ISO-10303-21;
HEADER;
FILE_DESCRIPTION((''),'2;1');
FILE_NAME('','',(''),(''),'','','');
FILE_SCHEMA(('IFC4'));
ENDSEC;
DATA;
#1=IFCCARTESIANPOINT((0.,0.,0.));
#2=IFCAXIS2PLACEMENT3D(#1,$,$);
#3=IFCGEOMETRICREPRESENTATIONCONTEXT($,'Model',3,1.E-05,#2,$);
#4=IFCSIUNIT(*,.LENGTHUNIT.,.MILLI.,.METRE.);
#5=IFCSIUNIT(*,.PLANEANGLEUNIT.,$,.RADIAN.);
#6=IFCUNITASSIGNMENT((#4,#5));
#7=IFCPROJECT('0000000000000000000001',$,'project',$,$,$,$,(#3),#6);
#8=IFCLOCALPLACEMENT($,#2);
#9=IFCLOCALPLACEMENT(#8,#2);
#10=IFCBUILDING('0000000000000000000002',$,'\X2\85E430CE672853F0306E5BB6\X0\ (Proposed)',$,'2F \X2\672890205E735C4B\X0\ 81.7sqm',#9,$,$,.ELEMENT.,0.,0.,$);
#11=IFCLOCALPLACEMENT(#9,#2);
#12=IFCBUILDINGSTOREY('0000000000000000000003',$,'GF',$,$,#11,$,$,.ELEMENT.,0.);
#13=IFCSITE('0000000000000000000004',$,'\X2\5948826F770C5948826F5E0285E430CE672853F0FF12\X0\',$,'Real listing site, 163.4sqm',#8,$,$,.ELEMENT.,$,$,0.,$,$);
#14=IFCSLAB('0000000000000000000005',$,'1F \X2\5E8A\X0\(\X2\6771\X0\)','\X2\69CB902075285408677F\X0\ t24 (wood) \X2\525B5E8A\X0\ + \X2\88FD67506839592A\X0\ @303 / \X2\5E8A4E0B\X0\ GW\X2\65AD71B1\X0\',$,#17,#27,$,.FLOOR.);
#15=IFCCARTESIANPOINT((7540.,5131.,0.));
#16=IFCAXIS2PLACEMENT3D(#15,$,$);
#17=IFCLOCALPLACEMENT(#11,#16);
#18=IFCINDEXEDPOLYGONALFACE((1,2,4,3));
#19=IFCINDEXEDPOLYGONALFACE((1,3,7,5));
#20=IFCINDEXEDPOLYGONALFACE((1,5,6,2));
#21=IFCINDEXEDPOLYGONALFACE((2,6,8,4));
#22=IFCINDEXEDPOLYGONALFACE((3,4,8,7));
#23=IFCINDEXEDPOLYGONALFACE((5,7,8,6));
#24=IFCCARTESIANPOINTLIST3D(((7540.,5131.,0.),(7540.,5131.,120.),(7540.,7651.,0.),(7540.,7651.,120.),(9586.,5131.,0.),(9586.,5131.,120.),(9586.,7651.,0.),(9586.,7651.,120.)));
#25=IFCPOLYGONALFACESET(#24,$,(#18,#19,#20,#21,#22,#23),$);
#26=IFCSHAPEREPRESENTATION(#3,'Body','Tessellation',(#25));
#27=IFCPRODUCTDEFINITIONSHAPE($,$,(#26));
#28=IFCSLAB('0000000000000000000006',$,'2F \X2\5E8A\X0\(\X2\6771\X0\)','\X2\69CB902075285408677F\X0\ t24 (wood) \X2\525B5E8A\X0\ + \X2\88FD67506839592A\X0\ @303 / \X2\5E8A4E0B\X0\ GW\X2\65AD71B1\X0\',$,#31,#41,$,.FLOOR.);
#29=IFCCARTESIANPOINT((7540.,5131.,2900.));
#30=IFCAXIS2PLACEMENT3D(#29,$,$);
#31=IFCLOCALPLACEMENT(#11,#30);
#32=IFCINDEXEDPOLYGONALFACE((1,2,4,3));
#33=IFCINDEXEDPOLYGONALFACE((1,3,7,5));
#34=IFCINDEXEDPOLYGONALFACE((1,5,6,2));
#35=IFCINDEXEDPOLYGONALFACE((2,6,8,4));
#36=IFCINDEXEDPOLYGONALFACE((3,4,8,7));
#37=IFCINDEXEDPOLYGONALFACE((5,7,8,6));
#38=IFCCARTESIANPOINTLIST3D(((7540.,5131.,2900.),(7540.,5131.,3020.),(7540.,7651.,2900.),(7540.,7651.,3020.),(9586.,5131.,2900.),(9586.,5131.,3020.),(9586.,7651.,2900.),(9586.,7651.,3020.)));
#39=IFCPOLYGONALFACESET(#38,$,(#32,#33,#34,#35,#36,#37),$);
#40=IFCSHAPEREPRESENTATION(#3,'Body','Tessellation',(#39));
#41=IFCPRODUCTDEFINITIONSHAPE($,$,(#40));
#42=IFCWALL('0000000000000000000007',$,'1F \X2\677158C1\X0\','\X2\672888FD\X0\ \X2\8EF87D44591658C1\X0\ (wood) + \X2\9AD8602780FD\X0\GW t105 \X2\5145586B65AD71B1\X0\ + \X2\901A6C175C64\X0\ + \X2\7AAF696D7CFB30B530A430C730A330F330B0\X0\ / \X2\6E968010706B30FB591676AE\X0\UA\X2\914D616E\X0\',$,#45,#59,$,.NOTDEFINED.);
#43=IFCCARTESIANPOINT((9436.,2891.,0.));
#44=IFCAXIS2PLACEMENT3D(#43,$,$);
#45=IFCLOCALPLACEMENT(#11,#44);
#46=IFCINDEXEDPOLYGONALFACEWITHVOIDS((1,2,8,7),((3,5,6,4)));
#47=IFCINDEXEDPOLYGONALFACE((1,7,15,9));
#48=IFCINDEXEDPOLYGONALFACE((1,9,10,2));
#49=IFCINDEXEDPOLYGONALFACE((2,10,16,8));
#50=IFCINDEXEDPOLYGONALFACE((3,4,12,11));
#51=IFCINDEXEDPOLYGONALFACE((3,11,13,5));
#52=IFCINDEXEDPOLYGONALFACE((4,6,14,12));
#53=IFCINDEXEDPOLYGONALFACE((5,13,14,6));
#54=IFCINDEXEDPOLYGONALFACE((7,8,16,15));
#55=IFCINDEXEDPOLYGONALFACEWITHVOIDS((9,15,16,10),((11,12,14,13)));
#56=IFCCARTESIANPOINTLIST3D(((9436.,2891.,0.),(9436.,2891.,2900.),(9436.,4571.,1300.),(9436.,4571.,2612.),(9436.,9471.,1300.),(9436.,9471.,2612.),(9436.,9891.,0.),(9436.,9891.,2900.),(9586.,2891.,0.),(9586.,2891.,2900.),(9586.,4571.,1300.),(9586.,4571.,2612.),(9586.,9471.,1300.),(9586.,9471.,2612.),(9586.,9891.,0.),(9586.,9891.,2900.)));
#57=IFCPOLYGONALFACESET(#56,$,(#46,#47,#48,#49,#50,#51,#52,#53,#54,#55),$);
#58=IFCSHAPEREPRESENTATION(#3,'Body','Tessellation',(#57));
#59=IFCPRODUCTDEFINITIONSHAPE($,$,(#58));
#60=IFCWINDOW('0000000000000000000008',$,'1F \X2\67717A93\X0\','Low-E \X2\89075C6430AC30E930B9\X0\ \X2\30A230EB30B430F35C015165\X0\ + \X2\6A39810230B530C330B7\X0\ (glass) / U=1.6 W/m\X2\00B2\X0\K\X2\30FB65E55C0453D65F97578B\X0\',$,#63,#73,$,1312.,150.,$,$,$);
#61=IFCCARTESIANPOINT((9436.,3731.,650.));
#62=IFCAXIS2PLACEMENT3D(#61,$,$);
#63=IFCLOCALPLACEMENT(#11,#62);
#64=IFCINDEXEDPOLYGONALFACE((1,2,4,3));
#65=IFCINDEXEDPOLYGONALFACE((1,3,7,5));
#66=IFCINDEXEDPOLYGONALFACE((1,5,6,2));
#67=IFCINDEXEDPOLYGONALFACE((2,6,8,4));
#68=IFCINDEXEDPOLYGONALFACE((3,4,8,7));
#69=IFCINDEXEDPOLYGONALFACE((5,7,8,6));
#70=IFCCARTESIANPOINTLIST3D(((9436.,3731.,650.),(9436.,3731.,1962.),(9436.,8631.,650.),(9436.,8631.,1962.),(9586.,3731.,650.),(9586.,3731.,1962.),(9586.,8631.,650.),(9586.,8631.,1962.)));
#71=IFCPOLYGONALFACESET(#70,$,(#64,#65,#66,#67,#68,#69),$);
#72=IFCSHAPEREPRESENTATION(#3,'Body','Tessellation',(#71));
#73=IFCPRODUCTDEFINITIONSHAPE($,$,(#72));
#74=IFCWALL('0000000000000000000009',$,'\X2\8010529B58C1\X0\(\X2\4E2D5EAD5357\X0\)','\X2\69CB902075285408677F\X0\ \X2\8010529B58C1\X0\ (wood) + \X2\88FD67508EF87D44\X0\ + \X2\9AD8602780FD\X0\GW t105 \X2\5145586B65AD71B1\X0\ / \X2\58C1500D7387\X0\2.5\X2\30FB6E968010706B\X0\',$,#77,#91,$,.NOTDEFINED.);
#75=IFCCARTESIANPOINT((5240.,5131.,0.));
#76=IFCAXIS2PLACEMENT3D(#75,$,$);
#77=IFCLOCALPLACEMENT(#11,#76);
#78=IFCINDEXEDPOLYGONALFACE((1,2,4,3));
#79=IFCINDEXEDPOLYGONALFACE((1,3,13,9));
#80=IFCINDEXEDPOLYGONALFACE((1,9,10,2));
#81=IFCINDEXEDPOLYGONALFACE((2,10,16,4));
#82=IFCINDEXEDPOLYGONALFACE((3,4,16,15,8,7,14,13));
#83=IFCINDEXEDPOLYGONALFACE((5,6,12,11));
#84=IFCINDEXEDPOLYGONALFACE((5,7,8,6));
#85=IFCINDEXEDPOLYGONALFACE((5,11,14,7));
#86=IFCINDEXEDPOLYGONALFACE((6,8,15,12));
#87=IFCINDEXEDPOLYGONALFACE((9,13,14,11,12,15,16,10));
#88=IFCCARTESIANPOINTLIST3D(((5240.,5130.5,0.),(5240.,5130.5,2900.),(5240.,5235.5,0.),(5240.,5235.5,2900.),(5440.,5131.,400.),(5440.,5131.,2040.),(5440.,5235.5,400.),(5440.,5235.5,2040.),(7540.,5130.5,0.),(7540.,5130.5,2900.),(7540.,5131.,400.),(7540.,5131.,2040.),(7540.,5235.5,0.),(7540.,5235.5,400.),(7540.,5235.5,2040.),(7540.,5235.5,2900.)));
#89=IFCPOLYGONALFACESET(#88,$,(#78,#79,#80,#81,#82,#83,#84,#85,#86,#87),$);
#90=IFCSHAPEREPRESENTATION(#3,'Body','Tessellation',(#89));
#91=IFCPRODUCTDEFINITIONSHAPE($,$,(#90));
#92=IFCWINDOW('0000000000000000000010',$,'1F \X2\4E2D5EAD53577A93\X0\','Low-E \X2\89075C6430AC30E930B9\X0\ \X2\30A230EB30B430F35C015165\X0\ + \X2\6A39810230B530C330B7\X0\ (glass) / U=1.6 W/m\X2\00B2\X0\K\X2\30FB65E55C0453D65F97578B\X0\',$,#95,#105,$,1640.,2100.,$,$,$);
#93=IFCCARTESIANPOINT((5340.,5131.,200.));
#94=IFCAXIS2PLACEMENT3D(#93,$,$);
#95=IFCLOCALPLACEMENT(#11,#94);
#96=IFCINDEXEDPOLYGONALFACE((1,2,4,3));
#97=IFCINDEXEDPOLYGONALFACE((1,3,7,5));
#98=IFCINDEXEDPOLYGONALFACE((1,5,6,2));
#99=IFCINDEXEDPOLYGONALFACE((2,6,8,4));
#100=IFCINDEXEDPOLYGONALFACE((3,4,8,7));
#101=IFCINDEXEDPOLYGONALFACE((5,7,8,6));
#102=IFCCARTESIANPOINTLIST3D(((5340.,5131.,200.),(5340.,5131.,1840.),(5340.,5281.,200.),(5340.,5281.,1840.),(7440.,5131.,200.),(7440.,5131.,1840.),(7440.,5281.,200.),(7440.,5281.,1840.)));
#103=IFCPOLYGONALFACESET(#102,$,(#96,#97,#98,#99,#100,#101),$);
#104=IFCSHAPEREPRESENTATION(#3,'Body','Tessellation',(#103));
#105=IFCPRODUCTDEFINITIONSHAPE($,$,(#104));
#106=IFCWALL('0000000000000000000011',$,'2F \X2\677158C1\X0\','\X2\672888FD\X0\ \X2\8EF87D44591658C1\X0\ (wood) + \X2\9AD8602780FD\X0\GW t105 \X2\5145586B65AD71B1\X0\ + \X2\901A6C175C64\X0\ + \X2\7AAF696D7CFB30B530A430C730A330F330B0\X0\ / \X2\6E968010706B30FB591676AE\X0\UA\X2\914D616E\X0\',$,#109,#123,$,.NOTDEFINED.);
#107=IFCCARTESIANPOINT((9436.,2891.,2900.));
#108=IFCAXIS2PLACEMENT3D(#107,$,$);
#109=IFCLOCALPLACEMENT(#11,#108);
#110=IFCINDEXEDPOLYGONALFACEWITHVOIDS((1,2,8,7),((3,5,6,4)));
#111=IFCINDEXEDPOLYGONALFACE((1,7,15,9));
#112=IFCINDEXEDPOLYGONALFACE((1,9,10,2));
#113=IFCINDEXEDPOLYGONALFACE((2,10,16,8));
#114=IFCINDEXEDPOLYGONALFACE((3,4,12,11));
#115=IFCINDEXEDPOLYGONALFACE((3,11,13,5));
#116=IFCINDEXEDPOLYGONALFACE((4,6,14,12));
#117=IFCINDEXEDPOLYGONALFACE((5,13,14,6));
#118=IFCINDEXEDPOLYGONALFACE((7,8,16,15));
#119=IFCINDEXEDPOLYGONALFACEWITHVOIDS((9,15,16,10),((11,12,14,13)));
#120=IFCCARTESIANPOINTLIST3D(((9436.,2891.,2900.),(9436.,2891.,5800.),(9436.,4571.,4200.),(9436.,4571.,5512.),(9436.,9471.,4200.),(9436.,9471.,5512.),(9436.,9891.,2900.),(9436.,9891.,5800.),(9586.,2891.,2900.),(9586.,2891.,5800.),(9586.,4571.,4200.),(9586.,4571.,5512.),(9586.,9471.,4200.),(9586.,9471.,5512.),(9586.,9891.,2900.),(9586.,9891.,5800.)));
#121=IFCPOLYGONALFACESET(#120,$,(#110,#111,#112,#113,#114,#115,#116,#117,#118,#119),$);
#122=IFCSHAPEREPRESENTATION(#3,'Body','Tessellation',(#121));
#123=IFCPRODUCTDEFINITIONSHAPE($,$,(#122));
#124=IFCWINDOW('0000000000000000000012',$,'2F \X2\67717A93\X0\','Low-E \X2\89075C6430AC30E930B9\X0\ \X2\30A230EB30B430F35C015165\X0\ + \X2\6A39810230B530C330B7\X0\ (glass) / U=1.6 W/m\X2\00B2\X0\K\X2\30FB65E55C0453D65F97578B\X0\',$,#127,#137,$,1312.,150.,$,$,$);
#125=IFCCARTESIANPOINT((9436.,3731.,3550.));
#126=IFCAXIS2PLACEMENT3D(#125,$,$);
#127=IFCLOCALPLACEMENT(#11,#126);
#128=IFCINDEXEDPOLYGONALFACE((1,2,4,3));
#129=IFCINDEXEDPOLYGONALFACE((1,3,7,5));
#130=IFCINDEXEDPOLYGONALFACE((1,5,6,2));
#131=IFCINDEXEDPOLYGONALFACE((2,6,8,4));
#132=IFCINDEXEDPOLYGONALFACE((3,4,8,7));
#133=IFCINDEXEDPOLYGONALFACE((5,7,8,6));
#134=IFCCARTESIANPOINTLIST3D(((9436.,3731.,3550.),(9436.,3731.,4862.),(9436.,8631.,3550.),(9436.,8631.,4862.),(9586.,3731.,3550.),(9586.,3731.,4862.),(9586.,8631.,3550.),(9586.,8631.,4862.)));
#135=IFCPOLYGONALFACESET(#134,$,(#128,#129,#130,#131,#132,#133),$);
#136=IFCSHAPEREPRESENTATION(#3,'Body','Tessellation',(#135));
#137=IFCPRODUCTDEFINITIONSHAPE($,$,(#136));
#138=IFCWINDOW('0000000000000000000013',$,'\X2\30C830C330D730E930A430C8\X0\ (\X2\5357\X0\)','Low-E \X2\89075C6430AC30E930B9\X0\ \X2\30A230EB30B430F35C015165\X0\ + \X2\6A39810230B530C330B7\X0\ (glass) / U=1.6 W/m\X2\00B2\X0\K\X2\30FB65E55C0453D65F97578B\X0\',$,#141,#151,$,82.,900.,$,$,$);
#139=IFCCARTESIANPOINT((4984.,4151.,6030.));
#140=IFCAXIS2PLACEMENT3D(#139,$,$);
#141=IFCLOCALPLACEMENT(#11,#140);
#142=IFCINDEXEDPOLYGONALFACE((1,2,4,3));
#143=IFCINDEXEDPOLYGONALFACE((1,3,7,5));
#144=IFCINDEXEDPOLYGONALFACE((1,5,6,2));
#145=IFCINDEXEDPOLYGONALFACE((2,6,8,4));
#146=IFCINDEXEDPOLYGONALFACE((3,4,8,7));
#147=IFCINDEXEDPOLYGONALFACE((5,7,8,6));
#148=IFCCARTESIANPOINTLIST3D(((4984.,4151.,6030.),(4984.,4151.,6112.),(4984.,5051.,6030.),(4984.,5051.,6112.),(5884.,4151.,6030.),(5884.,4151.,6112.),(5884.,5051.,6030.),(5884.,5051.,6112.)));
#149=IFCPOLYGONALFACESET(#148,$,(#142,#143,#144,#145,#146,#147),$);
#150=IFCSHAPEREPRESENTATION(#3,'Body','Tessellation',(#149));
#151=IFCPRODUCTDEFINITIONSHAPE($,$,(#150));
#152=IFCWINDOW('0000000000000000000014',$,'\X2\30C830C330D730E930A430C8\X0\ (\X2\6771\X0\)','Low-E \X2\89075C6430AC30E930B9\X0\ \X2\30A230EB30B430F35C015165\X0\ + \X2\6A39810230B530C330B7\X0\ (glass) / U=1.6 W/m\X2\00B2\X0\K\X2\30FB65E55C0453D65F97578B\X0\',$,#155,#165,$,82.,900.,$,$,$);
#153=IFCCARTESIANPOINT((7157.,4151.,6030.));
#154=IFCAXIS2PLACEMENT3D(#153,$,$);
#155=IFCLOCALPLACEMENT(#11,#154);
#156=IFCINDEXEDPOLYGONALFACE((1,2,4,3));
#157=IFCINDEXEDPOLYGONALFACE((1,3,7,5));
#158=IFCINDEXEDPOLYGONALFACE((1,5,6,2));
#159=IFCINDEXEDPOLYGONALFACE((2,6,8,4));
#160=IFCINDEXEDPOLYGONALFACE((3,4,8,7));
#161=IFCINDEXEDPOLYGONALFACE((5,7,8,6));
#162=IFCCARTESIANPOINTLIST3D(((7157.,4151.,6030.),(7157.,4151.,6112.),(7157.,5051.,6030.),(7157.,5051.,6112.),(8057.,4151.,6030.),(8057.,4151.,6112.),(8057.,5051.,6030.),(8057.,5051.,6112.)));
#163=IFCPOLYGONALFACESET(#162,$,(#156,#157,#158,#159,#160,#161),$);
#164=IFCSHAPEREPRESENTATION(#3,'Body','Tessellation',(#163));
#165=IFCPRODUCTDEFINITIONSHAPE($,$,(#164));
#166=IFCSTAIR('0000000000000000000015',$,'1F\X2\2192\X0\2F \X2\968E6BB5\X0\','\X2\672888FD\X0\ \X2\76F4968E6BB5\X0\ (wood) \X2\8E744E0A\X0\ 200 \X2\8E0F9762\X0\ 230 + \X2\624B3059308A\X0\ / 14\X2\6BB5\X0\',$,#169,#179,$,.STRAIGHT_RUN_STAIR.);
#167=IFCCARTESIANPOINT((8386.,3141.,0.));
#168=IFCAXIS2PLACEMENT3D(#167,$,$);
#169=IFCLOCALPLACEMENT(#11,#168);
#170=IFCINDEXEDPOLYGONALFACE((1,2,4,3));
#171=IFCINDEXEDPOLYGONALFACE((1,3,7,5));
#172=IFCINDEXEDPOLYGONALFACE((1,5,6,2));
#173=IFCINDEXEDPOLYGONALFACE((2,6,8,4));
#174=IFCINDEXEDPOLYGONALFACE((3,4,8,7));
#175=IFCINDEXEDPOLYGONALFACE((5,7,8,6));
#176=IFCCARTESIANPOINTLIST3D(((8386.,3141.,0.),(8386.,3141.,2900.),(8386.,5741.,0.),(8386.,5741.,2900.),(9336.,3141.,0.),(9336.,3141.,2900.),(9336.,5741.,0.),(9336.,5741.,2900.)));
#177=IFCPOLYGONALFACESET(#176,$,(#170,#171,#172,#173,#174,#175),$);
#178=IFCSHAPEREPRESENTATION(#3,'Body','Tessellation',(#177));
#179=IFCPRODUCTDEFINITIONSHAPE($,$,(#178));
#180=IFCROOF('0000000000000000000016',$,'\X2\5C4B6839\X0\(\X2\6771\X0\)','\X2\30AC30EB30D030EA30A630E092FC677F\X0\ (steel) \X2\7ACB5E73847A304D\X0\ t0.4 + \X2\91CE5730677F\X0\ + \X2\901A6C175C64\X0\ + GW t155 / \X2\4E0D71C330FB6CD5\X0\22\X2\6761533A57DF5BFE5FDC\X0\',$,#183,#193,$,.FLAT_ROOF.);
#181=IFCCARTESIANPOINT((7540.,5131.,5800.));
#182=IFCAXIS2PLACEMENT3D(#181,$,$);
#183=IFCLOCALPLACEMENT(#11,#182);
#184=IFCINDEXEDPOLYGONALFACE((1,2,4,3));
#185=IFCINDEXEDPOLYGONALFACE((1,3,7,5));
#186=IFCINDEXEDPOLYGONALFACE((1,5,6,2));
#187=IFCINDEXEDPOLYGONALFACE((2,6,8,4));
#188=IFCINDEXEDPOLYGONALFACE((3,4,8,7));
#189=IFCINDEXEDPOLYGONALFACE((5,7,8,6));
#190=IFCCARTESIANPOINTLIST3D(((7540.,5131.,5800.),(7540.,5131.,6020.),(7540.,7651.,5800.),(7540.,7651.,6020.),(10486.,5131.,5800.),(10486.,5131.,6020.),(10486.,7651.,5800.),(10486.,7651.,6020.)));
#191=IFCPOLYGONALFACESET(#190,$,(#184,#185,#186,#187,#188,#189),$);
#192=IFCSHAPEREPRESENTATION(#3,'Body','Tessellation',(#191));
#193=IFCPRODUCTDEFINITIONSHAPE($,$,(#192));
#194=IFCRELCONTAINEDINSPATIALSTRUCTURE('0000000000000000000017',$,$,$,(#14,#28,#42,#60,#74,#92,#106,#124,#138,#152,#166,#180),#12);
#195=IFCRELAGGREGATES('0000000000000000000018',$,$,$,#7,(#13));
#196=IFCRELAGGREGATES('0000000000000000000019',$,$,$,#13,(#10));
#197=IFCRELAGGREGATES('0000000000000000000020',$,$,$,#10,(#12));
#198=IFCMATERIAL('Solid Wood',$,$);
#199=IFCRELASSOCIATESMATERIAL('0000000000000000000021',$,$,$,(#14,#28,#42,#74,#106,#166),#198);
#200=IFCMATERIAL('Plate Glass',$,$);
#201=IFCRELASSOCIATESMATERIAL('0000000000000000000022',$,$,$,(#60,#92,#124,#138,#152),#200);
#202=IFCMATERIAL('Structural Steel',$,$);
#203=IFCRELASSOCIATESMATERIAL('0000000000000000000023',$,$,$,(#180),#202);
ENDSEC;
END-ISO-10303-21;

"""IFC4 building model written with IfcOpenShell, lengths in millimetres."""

from ifc_helpers import new_model, si_unit, frame, frame_2d, origin, place, context, project, spatial, rectangle, extrude, material, element, fill, save


model = new_model("IFC4")

# Units and contexts
model_context = context("Model", 3, precision=1e-05, world=origin())
ifc_project = project(units=[si_unit("LENGTHUNIT", "METRE", prefix="MILLI"), si_unit("PLANEANGLEUNIT", "RADIAN")], contexts=[model_context])

# Site, building, storey
site_placement = place(None, origin())
site = spatial("IfcSite", under=ifc_project, at=site_placement, Name="奈良県奈良市藤ノ木台２", ObjectType="Real listing site, 163.4sqm", CompositionType="ELEMENT", RefElevation=0.0)
building_placement = place(site_placement, origin())
building = spatial("IfcBuilding", under=site, at=building_placement, Name="藤ノ木台の家 (Proposed)", ObjectType="2F 木造平屋 81.7sqm", CompositionType="ELEMENT", ElevationOfRefHeight=0.0, ElevationOfTerrain=0.0)
storey_placement = place(building_placement, origin())
storey = spatial("IfcBuildingStorey", under=building, at=storey_placement, Name="GF", CompositionType="ELEMENT", Elevation=0.0)

# Slabs
ifc_material_1 = material(Name="Solid Wood")
slab_1_placement = place(storey_placement, frame((7540.0, 5131.0, 0.0)))
element("IfcSlab", 1, at=slab_1_placement, inside=storey, material=ifc_material_1, Name="1F 床(東)", Description="構造用合板 t24 (wood) 剛床 + 製材根太 @303 / 床下 GW断熱", PredefinedType="FLOOR", context=model_context, shape_type="SweptSolid", body=[
    extrude(rectangle(XDim=2046.0, YDim=2520.0, at=frame_2d((1023.0, 1260.0))), frame((7540.0, 5131.0, 0.0)), (0.0, 0.0, 1.0), 120.0),
])
slab_2_placement = place(storey_placement, frame((7540.0, 5131.0, 2900.0)))
element("IfcSlab", 2, at=slab_2_placement, inside=storey, material=ifc_material_1, Name="2F 床(東)", Description="構造用合板 t24 (wood) 剛床 + 製材根太 @303 / 床下 GW断熱", PredefinedType="FLOOR", context=model_context, shape_type="SweptSolid", body=[
    extrude(rectangle(XDim=2046.0, YDim=2520.0, at=frame_2d((1023.0, 1260.0))), frame((7540.0, 5131.0, 2900.0)), (0.0, 0.0, 1.0), 120.0),
])

# Walls, openings, windows
wall_1_placement = place(storey_placement, frame((9436.0, 2891.0, 0.0)))
wall_1 = element("IfcWall", 3, at=wall_1_placement, inside=storey, material=ifc_material_1, Name="1F 東壁", Description="木製 軸組外壁 (wood) + 高性能GW t105 充填断熱 + 通気層 + 窯業系サイディング / 準耐火・外皮UA配慮", PredefinedType="NOTDEFINED", context=model_context, shape_type="SweptSolid", body=[
    extrude(rectangle(XDim=150.0, YDim=7000.0, at=frame_2d((75.0, 3500.0))), frame((9436.0, 2891.0, 0.0)), (0.0, 0.0, 1.0), 2900.0),
])
opening_1_placement = place(storey_placement, frame((9436.0, 3731.0, 650.0)))
opening_1 = element("IfcOpeningElement", 4, at=opening_1_placement, cuts=wall_1, PredefinedType="NOTDEFINED", context=model_context, shape_type="SweptSolid", body=[
    extrude(rectangle(XDim=150.0, YDim=4900.0, at=frame_2d((75.0, 2450.0))), frame((9436.0, 3731.0, 650.0)), (0.0, 0.0, 1.0), 1312.0),
])
ifc_material_2 = material(Name="Plate Glass")
window_1_placement = place(storey_placement, frame((9436.0, 3731.0, 650.0)))
window_1 = element("IfcWindow", 5, at=window_1_placement, inside=storey, material=ifc_material_2, Name="1F 東窓", Description="Low-E 複層ガラス アルゴン封入 + 樹脂サッシ (glass) / U=1.6 W/m²K・日射取得型", OverallHeight=1312.0, OverallWidth=150.0, context=model_context, shape_type="SweptSolid", body=[
    extrude(rectangle(XDim=150.0, YDim=4900.0, at=frame_2d((75.0, 2450.0))), frame((9436.0, 3731.0, 650.0)), (0.0, 0.0, 1.0), 1312.0),
])
fill(opening_1, window_1)
wall_2_placement = place(storey_placement, frame((5240.0, 5131.0, 0.0)))
wall_2 = element("IfcWall", 6, at=wall_2_placement, inside=storey, material=ifc_material_1, Name="耐力壁(中庭南)", Description="構造用合板 耐力壁 (wood) + 製材軸組 + 高性能GW t105 充填断熱 / 壁倍率2.5・準耐火", PredefinedType="NOTDEFINED", context=model_context, shape_type="SweptSolid", body=[
    extrude(rectangle(XDim=2300.0, YDim=105.0, at=frame_2d((1150.0, 52.0))), frame((5240.0, 5131.0, 0.0)), (0.0, 0.0, 1.0), 2900.0),
])
opening_2_placement = place(storey_placement, frame((5340.0, 5131.0, 200.0)))
opening_2 = element("IfcOpeningElement", 7, at=opening_2_placement, cuts=wall_2, PredefinedType="NOTDEFINED", context=model_context, shape_type="SweptSolid", body=[
    extrude(rectangle(XDim=2100.0, YDim=150.0, at=frame_2d((1050.0, 75.0))), frame((5340.0, 5131.0, 200.0)), (0.0, 0.0, 1.0), 1640.0),
])
window_2_placement = place(storey_placement, frame((5340.0, 5131.0, 200.0)))
window_2 = element("IfcWindow", 8, at=window_2_placement, inside=storey, material=ifc_material_2, Name="1F 中庭南窓", Description="Low-E 複層ガラス アルゴン封入 + 樹脂サッシ (glass) / U=1.6 W/m²K・日射取得型", OverallHeight=1640.0, OverallWidth=2100.0, context=model_context, shape_type="SweptSolid", body=[
    extrude(rectangle(XDim=2100.0, YDim=150.0, at=frame_2d((1050.0, 75.0))), frame((5340.0, 5131.0, 200.0)), (0.0, 0.0, 1.0), 1640.0),
])
fill(opening_2, window_2)

# Wall, opening, window
wall_3_placement = place(storey_placement, frame((9436.0, 2891.0, 2900.0)))
wall_3 = element("IfcWall", 9, at=wall_3_placement, inside=storey, material=ifc_material_1, Name="2F 東壁", Description="木製 軸組外壁 (wood) + 高性能GW t105 充填断熱 + 通気層 + 窯業系サイディング / 準耐火・外皮UA配慮", PredefinedType="NOTDEFINED", context=model_context, shape_type="SweptSolid", body=[
    extrude(rectangle(XDim=150.0, YDim=7000.0, at=frame_2d((75.0, 3500.0))), frame((9436.0, 2891.0, 2900.0)), (0.0, 0.0, 1.0), 2900.0),
])
opening_3_placement = place(storey_placement, frame((9436.0, 3731.0, 3550.0)))
opening_3 = element("IfcOpeningElement", 10, at=opening_3_placement, cuts=wall_3, PredefinedType="NOTDEFINED", context=model_context, shape_type="SweptSolid", body=[
    extrude(rectangle(XDim=150.0, YDim=4900.0, at=frame_2d((75.0, 2450.0))), frame((9436.0, 3731.0, 3550.0)), (0.0, 0.0, 1.0), 1312.0),
])
window_3_placement = place(storey_placement, frame((9436.0, 3731.0, 3550.0)))
window_3 = element("IfcWindow", 11, at=window_3_placement, inside=storey, material=ifc_material_2, Name="2F 東窓", Description="Low-E 複層ガラス アルゴン封入 + 樹脂サッシ (glass) / U=1.6 W/m²K・日射取得型", OverallHeight=1312.0, OverallWidth=150.0, context=model_context, shape_type="SweptSolid", body=[
    extrude(rectangle(XDim=150.0, YDim=4900.0, at=frame_2d((75.0, 2450.0))), frame((9436.0, 3731.0, 3550.0)), (0.0, 0.0, 1.0), 1312.0),
])
fill(opening_3, window_3)

# Windows
window_4_placement = place(storey_placement, frame((4984.0, 4151.0, 6030.0)))
element("IfcWindow", 12, at=window_4_placement, inside=storey, material=ifc_material_2, Name="トップライト (南)", Description="Low-E 複層ガラス アルゴン封入 + 樹脂サッシ (glass) / U=1.6 W/m²K・日射取得型", OverallHeight=82.0, OverallWidth=900.0, context=model_context, shape_type="SweptSolid", body=[
    extrude(rectangle(XDim=900.0, YDim=900.0, at=frame_2d((450.0, 450.0))), frame((4984.0, 4151.0, 6030.0)), (0.0, 0.0, 1.0), 82.0),
])
window_5_placement = place(storey_placement, frame((7157.0, 4151.0, 6030.0)))
element("IfcWindow", 13, at=window_5_placement, inside=storey, material=ifc_material_2, Name="トップライト (東)", Description="Low-E 複層ガラス アルゴン封入 + 樹脂サッシ (glass) / U=1.6 W/m²K・日射取得型", OverallHeight=82.0, OverallWidth=900.0, context=model_context, shape_type="SweptSolid", body=[
    extrude(rectangle(XDim=900.0, YDim=900.0, at=frame_2d((450.0, 450.0))), frame((7157.0, 4151.0, 6030.0)), (0.0, 0.0, 1.0), 82.0),
])

# Stair
stair_placement = place(storey_placement, frame((8386.0, 3141.0, 0.0)))
element("IfcStair", 14, at=stair_placement, inside=storey, material=ifc_material_1, Name="1F→2F 階段", Description="木製 直階段 (wood) 蹴上 200 踏面 230 + 手すり / 14段", PredefinedType="STRAIGHT_RUN_STAIR", context=model_context, shape_type="SweptSolid", body=[
    extrude(rectangle(XDim=950.0, YDim=2600.0, at=frame_2d((475.0, 1300.0))), frame((8386.0, 3141.0, 0.0)), (0.0, 0.0, 1.0), 2900.0),
])

# Roof
ifc_material_3 = material(Name="Structural Steel")
roof_placement = place(storey_placement, frame((7540.0, 5131.0, 5800.0)))
element("IfcRoof", 15, at=roof_placement, inside=storey, material=ifc_material_3, Name="屋根(東)", Description="ガルバリウム鋼板 (steel) 立平葺き t0.4 + 野地板 + 通気層 + GW t155 / 不燃・法22条区域対応", PredefinedType="FLAT_ROOF", context=model_context, shape_type="SweptSolid", body=[
    extrude(rectangle(XDim=2946.0, YDim=2520.0, at=frame_2d((1473.0, 1260.0))), frame((7540.0, 5131.0, 5800.0)), (0.0, 0.0, 1.0), 220.0),
])

save(model, "model.ifc")
